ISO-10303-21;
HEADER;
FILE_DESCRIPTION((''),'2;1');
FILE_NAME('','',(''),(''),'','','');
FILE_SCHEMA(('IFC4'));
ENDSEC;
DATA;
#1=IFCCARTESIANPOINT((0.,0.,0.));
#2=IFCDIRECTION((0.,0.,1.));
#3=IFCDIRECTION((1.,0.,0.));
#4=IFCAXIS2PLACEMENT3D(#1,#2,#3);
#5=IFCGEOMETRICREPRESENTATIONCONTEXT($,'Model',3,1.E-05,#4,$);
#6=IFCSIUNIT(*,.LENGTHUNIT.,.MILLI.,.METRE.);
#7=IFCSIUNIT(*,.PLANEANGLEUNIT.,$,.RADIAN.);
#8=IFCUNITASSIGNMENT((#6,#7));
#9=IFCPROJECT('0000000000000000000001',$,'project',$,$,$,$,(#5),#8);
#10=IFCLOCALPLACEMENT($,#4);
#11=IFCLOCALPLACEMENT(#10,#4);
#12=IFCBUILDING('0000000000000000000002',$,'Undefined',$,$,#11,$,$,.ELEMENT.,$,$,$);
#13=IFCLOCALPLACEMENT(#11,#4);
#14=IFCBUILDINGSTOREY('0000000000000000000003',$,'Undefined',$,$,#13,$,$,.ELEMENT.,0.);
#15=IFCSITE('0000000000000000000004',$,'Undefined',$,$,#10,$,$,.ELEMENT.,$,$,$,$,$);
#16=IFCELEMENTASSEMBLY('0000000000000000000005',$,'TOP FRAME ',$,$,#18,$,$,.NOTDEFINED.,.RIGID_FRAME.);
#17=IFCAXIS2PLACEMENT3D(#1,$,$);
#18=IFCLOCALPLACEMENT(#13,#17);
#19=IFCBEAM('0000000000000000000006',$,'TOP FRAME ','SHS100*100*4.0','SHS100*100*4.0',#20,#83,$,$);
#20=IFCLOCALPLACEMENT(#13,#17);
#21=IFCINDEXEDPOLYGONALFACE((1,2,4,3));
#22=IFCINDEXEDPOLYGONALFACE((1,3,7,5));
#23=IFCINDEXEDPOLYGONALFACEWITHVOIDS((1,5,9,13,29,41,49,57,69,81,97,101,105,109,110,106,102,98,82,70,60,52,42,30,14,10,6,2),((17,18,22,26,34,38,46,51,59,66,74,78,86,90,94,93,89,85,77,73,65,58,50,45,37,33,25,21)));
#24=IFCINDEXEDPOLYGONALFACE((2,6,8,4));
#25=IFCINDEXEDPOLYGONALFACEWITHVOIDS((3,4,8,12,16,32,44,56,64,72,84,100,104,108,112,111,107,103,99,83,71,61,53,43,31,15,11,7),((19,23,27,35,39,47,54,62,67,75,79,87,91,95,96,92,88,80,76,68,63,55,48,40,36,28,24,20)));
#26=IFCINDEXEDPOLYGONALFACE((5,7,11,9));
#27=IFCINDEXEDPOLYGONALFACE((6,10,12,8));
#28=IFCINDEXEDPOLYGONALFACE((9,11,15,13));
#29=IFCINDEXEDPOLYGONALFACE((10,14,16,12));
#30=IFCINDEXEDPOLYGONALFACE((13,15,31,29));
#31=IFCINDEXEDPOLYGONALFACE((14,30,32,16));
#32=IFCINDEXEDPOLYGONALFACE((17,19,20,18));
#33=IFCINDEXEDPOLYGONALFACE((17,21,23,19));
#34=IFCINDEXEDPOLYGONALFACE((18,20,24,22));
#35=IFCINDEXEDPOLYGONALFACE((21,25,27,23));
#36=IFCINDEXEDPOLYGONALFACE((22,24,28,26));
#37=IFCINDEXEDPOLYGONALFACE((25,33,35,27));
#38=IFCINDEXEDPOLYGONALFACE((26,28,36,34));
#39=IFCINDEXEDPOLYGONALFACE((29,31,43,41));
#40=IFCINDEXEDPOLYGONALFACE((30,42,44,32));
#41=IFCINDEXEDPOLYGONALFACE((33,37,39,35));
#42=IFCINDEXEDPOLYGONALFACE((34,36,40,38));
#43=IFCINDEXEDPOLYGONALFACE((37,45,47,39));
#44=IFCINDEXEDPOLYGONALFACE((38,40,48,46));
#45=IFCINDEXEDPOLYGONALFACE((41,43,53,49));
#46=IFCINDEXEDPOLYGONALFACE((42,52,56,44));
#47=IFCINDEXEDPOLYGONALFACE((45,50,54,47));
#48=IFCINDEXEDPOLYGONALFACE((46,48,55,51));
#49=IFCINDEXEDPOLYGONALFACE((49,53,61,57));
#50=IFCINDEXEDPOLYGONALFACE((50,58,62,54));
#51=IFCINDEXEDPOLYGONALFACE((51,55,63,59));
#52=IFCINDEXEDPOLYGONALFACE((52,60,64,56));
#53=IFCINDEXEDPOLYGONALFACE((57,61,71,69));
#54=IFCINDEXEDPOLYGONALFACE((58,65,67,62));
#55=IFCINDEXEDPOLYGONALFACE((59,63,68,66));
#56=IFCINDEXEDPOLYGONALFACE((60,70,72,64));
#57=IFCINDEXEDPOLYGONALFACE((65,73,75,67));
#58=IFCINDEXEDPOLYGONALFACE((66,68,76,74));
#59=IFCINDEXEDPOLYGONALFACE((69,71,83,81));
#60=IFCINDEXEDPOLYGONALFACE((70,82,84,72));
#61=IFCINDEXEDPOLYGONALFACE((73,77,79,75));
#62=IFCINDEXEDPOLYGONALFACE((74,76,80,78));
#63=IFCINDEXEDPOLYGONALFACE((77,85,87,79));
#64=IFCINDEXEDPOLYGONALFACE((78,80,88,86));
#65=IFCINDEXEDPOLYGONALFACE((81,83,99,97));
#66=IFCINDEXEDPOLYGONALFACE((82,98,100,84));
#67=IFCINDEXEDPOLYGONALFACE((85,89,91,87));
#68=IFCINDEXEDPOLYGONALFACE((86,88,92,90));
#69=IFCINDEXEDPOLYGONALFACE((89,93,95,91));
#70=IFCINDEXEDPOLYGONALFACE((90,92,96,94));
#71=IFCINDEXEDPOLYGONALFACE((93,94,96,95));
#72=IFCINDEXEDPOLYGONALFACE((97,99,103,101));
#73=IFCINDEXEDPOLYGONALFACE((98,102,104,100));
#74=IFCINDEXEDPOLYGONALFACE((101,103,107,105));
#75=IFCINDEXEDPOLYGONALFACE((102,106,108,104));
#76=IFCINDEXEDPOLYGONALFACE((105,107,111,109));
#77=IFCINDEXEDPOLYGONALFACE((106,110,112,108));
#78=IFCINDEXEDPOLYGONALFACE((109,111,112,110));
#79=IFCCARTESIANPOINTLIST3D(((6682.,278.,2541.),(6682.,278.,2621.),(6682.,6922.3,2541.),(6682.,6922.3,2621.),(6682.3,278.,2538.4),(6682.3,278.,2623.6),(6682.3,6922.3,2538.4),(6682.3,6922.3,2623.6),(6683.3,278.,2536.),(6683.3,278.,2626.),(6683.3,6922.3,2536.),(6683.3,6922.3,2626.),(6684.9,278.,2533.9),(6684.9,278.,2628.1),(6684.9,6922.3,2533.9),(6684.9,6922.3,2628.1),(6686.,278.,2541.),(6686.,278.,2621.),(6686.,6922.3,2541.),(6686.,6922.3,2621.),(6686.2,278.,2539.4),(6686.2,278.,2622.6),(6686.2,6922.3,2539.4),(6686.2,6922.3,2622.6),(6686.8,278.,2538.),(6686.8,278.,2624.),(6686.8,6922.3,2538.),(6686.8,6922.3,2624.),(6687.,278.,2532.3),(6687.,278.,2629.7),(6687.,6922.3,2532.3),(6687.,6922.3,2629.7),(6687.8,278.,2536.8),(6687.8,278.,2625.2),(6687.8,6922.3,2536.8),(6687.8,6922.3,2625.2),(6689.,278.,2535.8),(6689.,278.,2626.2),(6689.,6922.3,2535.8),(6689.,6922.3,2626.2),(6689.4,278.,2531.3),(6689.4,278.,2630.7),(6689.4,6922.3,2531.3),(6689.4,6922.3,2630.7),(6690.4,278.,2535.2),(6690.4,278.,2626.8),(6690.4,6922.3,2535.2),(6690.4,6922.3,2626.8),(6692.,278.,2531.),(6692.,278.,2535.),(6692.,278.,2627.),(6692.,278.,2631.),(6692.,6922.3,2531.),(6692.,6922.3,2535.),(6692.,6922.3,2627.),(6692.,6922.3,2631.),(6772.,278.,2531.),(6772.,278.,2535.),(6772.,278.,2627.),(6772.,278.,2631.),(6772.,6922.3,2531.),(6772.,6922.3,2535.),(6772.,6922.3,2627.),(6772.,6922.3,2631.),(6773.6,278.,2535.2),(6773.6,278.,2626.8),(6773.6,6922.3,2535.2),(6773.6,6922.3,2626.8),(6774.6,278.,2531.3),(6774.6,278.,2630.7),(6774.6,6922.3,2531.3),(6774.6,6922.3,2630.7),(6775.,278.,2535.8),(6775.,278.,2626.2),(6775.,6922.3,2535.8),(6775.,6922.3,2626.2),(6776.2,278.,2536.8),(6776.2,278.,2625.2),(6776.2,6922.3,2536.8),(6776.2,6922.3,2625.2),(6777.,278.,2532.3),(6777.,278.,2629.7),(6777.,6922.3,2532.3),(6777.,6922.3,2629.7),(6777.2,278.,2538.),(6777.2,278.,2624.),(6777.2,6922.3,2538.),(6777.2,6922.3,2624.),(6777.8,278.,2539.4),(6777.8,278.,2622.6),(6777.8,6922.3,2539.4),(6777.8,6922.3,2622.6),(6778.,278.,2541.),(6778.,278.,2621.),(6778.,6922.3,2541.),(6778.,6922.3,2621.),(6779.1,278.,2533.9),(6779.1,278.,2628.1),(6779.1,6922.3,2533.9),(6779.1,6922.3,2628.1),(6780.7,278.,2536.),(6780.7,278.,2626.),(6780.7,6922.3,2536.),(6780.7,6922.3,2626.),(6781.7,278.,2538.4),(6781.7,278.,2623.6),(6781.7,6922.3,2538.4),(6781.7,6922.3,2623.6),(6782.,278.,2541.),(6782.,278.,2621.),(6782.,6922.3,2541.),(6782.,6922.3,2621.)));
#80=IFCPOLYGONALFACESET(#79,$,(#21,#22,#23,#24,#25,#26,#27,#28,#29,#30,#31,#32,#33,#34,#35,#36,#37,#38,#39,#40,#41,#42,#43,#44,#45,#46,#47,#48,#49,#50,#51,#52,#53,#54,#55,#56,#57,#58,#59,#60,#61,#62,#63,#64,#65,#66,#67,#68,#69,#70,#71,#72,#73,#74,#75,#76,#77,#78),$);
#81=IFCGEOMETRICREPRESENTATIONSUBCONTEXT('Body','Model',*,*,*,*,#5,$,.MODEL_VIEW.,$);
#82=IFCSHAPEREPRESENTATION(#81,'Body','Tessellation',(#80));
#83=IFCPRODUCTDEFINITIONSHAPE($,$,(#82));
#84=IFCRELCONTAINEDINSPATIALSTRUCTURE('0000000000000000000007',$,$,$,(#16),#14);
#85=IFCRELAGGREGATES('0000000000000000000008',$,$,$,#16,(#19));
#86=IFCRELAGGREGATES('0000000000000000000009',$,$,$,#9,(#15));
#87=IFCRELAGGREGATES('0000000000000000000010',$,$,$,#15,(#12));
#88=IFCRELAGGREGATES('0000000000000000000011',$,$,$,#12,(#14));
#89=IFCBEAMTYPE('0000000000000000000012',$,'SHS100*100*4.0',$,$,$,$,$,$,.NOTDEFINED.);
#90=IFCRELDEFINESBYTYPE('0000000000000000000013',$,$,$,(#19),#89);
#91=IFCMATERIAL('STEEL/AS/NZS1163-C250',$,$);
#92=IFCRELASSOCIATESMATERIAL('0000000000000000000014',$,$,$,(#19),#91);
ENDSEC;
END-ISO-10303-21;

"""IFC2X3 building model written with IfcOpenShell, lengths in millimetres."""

from ifc_helpers import new_model, si_unit, frame, origin_with_axes, origin_2d_with_axis, place, context, subcontext, project, spatial, hollow_rectangle, extrude, material, type_object, element, aggregate, save


model = new_model("IFC2X3")

# Units and contexts
model_context = context("Model", 3, precision=1e-05, world=origin_with_axes())
body_context = subcontext(model_context, "Body", "Model", "MODEL_VIEW")
ifc_project = project(units=[si_unit("LENGTHUNIT", "METRE", prefix="MILLI"), si_unit("PLANEANGLEUNIT", "RADIAN")], contexts=[model_context])

# Site, building, storey
site_placement = place(None, origin_with_axes())
site = spatial("IfcSite", under=ifc_project, at=site_placement, Name="Undefined", CompositionType="ELEMENT")
building_placement = place(site_placement, origin_with_axes())
building = spatial("IfcBuilding", under=site, at=building_placement, Name="Undefined", CompositionType="ELEMENT")
storey_placement = place(building_placement, origin_with_axes())
storey = spatial("IfcBuildingStorey", under=building, at=storey_placement, Name="Undefined", CompositionType="ELEMENT", Elevation=0.0)

# Element assembly
ifc_material_1 = material(Name="STEEL/AS/NZS1163-C250")
assembly_1_placement = place(storey_placement, origin_with_axes())
assembly_1 = element("IfcElementAssembly", 1, at=assembly_1_placement, inside=storey, Name="TOP FRAME ", AssemblyPlace="NOTDEFINED", PredefinedType="RIGID_FRAME")

# Beam
beam_type_1 = type_object("IfcBeamType", Name="SHS100*100*4.0", PredefinedType="NOTDEFINED")
beam_1_placement = place(assembly_1_placement, frame((6732.0, 6922.3, 2581.0), z_axis=(0.0, 0.0, 1.0), x_axis=(0.0, -1.0, 0.0)))
beam_1 = element("IfcBeam", 2, at=beam_1_placement, type_object=beam_type_1, material=ifc_material_1, Name="TOP FRAME ", Description="SHS100*100*4.0", ObjectType="SHS100*100*4.0", context=body_context, shape_type="SweptSolid", body=[
    extrude(hollow_rectangle(XDim=100.0, YDim=100.0, WallThickness=4.0, InnerFilletRadius=6.0, OuterFilletRadius=10.0, at=origin_2d_with_axis()), frame((6644.3, 0.0, 0.0), z_axis=(-1.0, 0.0, 0.0), x_axis=(0.0, -1.0, 0.0)), (0.0, 0.0, 1.0), 6644.3),
])
aggregate(assembly_1, [beam_1])

save(model, "model.ifc")
